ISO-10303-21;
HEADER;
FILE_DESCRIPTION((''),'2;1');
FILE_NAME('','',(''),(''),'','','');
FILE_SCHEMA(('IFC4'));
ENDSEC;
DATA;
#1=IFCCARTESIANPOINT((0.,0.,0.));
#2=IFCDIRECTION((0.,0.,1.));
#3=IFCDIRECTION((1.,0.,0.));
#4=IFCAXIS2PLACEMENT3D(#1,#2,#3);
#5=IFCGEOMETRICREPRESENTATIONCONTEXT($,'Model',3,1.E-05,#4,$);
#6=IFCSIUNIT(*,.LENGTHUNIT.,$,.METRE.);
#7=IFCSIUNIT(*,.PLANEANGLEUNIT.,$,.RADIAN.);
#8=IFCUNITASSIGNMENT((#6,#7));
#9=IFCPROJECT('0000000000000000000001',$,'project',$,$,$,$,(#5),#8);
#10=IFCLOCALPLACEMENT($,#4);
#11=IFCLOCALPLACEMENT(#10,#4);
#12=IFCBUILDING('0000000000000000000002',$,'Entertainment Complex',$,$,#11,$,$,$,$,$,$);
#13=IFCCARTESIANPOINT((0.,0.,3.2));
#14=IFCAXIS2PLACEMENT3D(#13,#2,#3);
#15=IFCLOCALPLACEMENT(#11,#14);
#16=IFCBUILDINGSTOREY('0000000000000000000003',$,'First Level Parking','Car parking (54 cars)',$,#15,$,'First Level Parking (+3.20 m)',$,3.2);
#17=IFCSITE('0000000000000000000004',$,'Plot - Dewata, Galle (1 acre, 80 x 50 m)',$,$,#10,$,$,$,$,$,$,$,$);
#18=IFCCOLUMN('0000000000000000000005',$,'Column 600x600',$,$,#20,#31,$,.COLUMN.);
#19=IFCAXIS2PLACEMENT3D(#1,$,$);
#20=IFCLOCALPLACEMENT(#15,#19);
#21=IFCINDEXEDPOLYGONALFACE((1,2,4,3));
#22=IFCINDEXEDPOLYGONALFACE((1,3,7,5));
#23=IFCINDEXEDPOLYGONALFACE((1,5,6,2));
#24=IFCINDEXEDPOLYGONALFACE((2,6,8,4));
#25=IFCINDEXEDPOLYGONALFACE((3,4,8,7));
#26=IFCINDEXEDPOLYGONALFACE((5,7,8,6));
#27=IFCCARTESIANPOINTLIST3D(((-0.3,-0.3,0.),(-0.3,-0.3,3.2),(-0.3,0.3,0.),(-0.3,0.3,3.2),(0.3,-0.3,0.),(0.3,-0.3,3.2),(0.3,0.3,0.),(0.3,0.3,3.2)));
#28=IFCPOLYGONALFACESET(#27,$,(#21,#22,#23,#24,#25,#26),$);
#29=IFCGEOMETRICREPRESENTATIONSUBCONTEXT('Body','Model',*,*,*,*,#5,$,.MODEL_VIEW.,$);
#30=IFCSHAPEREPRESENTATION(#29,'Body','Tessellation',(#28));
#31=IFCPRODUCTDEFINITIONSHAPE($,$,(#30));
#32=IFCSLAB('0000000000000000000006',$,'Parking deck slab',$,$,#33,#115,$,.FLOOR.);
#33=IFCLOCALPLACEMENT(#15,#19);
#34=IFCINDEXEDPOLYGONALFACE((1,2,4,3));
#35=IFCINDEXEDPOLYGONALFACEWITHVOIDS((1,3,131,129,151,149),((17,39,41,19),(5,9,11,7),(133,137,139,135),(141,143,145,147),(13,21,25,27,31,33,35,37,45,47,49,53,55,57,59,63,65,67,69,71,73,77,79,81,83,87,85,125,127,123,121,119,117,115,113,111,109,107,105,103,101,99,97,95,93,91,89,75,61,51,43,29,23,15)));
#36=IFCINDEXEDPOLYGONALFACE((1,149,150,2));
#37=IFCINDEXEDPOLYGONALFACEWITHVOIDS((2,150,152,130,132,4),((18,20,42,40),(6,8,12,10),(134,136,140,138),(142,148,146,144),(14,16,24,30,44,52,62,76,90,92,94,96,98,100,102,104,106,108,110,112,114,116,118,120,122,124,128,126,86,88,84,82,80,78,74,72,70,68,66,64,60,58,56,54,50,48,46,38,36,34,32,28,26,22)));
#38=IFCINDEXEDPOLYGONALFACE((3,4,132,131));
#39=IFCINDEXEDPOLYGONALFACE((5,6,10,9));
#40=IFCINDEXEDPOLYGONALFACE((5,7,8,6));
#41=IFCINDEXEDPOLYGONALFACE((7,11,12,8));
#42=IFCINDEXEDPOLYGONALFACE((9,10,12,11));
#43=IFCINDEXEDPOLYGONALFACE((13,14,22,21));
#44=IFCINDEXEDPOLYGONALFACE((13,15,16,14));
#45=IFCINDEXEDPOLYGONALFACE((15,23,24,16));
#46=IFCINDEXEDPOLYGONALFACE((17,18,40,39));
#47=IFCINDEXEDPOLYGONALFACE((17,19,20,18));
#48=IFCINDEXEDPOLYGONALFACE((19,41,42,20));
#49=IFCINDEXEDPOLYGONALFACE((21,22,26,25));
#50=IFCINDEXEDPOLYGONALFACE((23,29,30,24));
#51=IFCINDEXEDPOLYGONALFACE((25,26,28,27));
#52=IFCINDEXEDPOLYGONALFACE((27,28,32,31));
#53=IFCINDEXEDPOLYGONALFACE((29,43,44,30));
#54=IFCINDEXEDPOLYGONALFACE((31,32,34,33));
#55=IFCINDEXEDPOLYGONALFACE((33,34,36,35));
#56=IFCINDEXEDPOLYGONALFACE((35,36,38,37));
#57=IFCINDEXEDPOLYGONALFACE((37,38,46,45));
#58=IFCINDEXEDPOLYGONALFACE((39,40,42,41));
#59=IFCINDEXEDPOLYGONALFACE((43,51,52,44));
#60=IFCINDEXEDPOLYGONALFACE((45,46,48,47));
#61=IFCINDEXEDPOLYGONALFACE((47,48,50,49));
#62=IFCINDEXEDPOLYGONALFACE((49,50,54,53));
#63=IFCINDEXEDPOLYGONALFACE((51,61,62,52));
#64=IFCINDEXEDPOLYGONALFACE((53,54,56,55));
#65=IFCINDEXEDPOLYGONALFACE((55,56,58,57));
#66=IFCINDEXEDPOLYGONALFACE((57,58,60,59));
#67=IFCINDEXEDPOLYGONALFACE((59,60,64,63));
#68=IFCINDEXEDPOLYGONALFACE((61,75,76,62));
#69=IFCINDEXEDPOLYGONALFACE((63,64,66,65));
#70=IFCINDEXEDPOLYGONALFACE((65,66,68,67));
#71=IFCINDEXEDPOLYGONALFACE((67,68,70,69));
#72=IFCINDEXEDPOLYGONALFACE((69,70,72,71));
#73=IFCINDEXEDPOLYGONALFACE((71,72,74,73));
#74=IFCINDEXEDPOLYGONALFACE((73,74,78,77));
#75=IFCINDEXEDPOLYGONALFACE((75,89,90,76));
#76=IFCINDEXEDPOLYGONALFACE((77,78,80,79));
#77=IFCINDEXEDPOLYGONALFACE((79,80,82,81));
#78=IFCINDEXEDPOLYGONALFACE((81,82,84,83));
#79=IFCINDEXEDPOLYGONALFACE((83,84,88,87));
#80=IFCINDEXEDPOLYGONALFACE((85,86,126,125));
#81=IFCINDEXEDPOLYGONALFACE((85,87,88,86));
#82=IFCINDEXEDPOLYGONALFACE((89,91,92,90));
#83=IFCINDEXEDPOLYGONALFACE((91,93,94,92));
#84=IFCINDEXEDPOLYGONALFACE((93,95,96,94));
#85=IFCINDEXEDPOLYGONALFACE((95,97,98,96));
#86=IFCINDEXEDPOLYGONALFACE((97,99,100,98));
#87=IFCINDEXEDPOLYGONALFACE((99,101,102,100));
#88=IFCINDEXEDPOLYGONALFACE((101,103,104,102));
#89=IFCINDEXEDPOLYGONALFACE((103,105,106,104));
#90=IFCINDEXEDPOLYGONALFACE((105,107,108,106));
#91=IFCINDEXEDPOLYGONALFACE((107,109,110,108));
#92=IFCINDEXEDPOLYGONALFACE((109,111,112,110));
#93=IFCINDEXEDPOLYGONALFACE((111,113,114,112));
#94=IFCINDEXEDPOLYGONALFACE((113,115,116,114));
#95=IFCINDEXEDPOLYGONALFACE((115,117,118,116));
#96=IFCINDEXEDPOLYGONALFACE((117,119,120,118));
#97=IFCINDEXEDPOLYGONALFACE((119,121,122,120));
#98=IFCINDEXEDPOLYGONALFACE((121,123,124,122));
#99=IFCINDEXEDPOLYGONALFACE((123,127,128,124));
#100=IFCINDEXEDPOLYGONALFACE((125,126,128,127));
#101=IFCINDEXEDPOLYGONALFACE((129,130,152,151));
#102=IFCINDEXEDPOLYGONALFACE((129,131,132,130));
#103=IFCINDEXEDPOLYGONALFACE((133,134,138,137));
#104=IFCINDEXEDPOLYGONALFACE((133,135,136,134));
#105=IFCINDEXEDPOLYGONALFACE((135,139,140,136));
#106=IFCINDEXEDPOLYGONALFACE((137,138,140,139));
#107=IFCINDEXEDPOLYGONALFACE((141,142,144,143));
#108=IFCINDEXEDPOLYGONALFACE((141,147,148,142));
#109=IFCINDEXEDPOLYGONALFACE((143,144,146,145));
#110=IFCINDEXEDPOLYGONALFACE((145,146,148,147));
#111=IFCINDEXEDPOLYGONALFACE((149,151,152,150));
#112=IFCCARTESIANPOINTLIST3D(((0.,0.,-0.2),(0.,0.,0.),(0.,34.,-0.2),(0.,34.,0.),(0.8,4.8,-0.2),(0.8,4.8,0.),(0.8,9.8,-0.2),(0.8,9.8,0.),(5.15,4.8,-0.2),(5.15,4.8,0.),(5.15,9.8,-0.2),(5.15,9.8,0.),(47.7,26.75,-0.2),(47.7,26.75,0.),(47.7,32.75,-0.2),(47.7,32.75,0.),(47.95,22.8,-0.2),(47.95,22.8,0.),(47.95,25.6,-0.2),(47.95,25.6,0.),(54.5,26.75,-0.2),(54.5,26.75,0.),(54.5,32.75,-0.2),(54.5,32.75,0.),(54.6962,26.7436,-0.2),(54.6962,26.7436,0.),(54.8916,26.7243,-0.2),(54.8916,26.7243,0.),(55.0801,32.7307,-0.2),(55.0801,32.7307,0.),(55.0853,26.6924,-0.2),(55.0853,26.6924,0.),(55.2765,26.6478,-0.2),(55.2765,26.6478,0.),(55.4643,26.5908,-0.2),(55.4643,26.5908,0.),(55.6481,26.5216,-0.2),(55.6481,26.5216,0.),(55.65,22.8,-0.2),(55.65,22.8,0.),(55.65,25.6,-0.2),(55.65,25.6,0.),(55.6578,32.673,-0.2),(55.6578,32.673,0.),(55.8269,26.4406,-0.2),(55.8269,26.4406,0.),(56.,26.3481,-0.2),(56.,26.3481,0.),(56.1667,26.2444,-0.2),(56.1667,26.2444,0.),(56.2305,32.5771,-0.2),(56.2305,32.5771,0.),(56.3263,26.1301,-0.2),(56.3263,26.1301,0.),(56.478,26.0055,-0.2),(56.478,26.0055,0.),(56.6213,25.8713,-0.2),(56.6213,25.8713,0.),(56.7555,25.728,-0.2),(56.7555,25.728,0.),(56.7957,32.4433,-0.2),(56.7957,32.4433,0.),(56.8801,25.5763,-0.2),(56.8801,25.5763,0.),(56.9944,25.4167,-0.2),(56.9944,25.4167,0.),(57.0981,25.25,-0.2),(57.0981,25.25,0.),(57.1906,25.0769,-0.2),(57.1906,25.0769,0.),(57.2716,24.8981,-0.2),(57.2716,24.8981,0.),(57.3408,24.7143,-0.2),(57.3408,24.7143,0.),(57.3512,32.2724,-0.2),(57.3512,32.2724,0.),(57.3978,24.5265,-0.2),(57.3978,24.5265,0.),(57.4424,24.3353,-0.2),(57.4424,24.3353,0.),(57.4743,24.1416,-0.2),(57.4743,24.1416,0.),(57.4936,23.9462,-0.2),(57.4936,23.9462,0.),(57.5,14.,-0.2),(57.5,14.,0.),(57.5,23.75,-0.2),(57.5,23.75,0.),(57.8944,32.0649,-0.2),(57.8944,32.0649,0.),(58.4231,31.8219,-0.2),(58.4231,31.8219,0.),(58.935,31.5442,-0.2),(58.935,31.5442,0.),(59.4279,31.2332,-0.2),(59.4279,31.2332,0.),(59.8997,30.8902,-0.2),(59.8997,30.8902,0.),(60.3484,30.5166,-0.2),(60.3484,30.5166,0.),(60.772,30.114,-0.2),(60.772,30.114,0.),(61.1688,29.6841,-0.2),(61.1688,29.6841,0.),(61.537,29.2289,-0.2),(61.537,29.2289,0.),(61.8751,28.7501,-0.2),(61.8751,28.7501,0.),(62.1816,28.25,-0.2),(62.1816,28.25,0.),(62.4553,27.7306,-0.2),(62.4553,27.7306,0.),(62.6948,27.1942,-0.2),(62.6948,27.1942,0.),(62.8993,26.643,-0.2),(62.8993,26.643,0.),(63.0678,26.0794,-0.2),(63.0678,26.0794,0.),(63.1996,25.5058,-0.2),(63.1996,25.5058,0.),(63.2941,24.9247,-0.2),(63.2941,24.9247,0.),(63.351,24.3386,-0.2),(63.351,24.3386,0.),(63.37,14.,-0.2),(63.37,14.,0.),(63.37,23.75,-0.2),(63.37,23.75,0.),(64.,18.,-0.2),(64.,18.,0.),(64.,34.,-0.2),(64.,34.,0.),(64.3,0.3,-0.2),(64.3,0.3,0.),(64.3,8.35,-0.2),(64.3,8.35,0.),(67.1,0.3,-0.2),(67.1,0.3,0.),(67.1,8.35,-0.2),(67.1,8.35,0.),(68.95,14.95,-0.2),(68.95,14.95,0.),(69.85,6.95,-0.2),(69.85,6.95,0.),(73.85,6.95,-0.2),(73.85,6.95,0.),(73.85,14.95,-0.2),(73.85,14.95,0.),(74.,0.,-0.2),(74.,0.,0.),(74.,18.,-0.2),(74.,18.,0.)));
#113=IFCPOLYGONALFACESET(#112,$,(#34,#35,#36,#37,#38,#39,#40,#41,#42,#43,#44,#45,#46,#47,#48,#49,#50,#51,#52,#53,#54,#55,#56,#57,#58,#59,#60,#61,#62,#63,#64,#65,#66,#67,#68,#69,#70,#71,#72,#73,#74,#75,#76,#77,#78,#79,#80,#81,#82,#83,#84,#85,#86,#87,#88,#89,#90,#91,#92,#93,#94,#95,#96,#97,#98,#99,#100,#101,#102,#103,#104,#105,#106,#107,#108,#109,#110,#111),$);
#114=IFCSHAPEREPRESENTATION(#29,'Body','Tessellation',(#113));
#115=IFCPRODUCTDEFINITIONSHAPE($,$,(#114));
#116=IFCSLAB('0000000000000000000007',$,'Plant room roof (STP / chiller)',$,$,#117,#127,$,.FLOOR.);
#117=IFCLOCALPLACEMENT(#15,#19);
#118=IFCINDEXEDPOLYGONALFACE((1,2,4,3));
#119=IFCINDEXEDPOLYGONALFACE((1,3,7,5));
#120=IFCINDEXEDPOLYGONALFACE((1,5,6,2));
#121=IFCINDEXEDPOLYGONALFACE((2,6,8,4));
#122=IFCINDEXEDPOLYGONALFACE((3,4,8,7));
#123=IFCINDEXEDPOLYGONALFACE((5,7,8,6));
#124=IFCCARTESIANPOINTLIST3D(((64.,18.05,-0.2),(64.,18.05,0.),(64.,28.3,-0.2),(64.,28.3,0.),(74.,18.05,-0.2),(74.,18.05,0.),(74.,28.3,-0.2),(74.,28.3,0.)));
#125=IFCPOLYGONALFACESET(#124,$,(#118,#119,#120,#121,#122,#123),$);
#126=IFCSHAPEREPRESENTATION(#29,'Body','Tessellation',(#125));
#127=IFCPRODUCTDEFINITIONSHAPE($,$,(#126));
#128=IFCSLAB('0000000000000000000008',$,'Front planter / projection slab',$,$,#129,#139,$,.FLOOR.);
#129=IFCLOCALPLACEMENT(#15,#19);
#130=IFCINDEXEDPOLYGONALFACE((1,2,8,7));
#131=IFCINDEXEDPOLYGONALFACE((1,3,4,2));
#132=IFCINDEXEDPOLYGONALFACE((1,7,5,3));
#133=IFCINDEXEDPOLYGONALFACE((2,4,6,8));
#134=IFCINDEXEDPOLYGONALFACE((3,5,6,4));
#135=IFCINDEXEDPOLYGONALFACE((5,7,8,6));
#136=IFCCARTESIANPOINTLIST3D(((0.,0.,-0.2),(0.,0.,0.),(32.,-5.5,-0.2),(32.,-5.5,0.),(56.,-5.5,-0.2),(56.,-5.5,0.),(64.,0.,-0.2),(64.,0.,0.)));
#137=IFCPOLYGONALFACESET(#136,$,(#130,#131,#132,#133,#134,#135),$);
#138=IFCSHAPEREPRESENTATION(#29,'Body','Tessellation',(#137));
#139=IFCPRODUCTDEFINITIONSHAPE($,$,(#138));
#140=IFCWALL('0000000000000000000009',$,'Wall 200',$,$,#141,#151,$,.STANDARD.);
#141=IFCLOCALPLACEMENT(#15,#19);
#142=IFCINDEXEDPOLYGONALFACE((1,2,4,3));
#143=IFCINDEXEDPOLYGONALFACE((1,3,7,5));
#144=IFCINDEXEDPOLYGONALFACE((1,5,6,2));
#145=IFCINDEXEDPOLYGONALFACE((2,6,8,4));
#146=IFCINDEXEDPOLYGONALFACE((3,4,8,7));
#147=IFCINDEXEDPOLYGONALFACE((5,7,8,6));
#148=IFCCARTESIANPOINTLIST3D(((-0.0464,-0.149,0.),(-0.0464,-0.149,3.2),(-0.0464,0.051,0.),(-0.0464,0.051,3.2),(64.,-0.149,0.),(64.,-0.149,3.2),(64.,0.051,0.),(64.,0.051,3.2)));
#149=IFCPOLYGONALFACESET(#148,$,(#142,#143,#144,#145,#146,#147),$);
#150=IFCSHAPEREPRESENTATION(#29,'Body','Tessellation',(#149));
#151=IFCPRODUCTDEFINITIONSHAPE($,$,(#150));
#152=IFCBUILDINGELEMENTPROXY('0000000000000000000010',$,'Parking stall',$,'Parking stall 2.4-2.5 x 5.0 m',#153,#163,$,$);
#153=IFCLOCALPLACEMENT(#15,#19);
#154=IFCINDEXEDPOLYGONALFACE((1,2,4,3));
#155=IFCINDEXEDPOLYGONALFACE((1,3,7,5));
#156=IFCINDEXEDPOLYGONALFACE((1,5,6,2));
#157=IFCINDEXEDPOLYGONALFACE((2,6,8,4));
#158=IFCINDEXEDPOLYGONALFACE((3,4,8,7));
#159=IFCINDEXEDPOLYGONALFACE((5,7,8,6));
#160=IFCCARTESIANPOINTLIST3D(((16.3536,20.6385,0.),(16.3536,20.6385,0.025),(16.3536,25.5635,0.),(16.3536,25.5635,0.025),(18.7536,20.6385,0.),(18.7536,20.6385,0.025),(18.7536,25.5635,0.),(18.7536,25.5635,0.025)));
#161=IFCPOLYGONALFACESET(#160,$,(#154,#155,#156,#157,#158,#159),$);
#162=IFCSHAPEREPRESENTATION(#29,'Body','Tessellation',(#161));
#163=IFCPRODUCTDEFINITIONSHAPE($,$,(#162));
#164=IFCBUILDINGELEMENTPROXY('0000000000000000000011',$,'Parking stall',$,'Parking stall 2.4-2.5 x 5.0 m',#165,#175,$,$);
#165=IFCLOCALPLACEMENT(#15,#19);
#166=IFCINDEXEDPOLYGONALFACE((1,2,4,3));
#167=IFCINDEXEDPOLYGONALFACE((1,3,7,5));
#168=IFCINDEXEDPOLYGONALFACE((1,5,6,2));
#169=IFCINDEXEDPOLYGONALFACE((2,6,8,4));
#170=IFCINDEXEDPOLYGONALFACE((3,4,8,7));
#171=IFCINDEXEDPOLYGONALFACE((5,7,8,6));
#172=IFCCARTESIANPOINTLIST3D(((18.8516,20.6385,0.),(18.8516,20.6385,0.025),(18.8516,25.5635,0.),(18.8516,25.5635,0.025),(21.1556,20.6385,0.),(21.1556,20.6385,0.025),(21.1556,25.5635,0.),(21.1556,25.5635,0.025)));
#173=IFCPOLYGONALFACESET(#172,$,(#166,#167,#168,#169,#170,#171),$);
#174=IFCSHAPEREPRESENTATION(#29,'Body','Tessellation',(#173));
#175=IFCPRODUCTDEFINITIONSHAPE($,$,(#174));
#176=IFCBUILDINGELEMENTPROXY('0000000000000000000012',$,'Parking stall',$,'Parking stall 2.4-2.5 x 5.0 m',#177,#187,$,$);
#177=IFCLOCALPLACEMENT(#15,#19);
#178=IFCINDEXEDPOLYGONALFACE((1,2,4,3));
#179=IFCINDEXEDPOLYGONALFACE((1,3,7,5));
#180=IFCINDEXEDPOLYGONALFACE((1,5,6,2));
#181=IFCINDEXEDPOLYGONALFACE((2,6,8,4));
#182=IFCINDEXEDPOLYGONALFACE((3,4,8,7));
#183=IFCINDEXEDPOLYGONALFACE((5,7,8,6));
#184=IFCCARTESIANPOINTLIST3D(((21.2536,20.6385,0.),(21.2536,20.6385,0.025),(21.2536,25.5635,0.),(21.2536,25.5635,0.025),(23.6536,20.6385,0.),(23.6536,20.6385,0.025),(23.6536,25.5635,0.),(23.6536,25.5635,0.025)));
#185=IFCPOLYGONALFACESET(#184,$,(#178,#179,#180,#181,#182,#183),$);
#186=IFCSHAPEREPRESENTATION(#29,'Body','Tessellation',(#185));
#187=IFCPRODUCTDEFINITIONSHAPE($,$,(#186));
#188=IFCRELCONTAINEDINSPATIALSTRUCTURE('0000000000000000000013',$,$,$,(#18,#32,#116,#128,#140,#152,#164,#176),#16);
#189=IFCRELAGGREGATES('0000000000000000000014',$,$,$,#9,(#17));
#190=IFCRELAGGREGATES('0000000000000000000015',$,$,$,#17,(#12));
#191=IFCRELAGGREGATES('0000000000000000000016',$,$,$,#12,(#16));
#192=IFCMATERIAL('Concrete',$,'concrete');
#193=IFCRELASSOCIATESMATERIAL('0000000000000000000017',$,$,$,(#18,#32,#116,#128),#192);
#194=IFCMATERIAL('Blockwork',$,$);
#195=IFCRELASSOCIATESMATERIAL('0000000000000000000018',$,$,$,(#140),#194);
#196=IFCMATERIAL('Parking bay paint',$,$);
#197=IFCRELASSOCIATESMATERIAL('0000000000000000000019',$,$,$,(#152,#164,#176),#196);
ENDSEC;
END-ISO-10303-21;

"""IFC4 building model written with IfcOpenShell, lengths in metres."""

from ifc_helpers import new_model, si_unit, frame, origin_with_axes, place, context, subcontext, project, spatial, polyline, outline, extrude, material, element, save


model = new_model("IFC4")

# Units and contexts
model_context = context("Model", 3, precision=1e-05, world=origin_with_axes())
body_context = subcontext(model_context, "Body", "Model", "MODEL_VIEW")
ifc_project = project(units=[si_unit("LENGTHUNIT", "METRE"), si_unit("PLANEANGLEUNIT", "RADIAN")], contexts=[model_context])

# Site, building, storey
site_placement = place(None, origin_with_axes())
site = spatial("IfcSite", under=ifc_project, at=site_placement, Name="Plot - Dewata, Galle (1 acre, 80 x 50 m)")
building_placement = place(site_placement, origin_with_axes())
building = spatial("IfcBuilding", under=site, at=building_placement, Name="Entertainment Complex")
storey_placement = place(building_placement, frame((0.0, 0.0, 3.2), z_axis=(0.0, 0.0, 1.0), x_axis=(1.0, 0.0, 0.0)))
storey = spatial("IfcBuildingStorey", under=building, at=storey_placement, Name="First Level Parking", Description="Car parking (54 cars)", LongName="First Level Parking (+3.20 m)", Elevation=3.2)

# Column
ifc_material_1 = material(Name="Concrete", Category="concrete")
column_placement = place(storey_placement, origin_with_axes())
element("IfcColumn", 1, at=column_placement, inside=storey, material=ifc_material_1, Name="Column 600x600", PredefinedType="COLUMN", context=body_context, shape_type="SweptSolid", body=[
    extrude(outline(polyline([(-0.3, -0.3), (0.3, -0.3), (0.3, 0.3), (-0.3, 0.3), (-0.3, -0.3)])), origin_with_axes(), (0.0, 0.0, 1.0), 3.2),
])

# Slabs
slab_1_placement = place(storey_placement, origin_with_axes())
element("IfcSlab", 2, at=slab_1_placement, inside=storey, material=ifc_material_1, Name="Parking deck slab", PredefinedType="FLOOR", context=body_context, shape_type="SweptSolid", body=[
    extrude(outline(polyline([(74.0, 18.0), (64.0, 18.0), (64.0, 34.0), (0.0, 34.0), (0.0, 0.0), (74.0, 0.0), (74.0, 18.0)]), holes=[polyline([(63.2941, 24.9247), (63.351, 24.3386), (63.37, 23.75), (63.37, 14.0), (57.5, 14.0), (57.5, 23.75), (57.4936, 23.9462), (57.4743, 24.1416), (57.4424, 24.3353), (57.3978, 24.5265), (57.3408, 24.7143), (57.2716, 24.8981), (57.1906, 25.0769), (57.0981, 25.25), (56.9944, 25.4167), (56.8801, 25.5763), (56.7555, 25.728), (56.6213, 25.8713), (56.478, 26.0055), (56.3263, 26.1301), (56.1667, 26.2444), (56.0, 26.3481), (55.8269, 26.4406), (55.6481, 26.5216), (55.4643, 26.5908), (55.2765, 26.6478), (55.0853, 26.6924), (54.8916, 26.7243), (54.6962, 26.7436), (54.5, 26.75), (47.7, 26.75), (47.7, 32.75), (54.5, 32.75), (55.0801, 32.7307), (55.6578, 32.673), (56.2305, 32.5771), (56.7957, 32.4433), (57.3512, 32.2724), (57.8944, 32.0649), (58.4231, 31.8219), (58.935, 31.5442), (59.4279, 31.2332), (59.8997, 30.8902), (60.3484, 30.5166), (60.772, 30.114), (61.1688, 29.6841), (61.537, 29.2289), (61.8751, 28.7501), (62.1816, 28.25), (62.4553, 27.7306), (62.6948, 27.1942), (62.8993, 26.643), (63.0678, 26.0794), (63.1996, 25.5058), (63.2941, 24.9247)]), polyline([(0.8, 9.8), (5.15, 9.8), (5.15, 4.8), (0.8, 4.8), (0.8, 9.8)]), polyline([(73.85, 6.95), (69.85, 6.95), (68.95, 14.95), (73.85, 14.95), (73.85, 6.95)]), polyline([(55.65, 22.8), (47.95, 22.8), (47.95, 25.6), (55.65, 25.6), (55.65, 22.8)]), polyline([(64.3, 0.3), (64.3, 8.35), (67.1, 8.35), (67.1, 0.3), (64.3, 0.3)])]), frame((0.0, 0.0, -0.2), z_axis=(0.0, 0.0, 1.0), x_axis=(1.0, 0.0, 0.0)), (0.0, 0.0, 1.0), 0.2),
])
slab_2_placement = place(storey_placement, origin_with_axes())
element("IfcSlab", 3, at=slab_2_placement, inside=storey, material=ifc_material_1, Name="Plant room roof (STP / chiller)", PredefinedType="FLOOR", context=body_context, shape_type="SweptSolid", body=[
    extrude(outline(polyline([(74.0, 18.05), (74.0, 28.3), (64.0, 28.3), (64.0, 18.05), (74.0, 18.05)])), frame((0.0, 0.0, -0.2), z_axis=(0.0, 0.0, 1.0), x_axis=(1.0, 0.0, 0.0)), (0.0, 0.0, 1.0), 0.2),
])
slab_3_placement = place(storey_placement, origin_with_axes())
element("IfcSlab", 4, at=slab_3_placement, inside=storey, material=ifc_material_1, Name="Front planter / projection slab", PredefinedType="FLOOR", context=body_context, shape_type="SweptSolid", body=[
    extrude(outline(polyline([(0.0, 0.0), (32.0, -5.5), (56.0, -5.5), (64.0, 0.0), (0.0, 0.0)])), frame((0.0, 0.0, -0.2), z_axis=(0.0, 0.0, 1.0), x_axis=(1.0, 0.0, 0.0)), (0.0, 0.0, 1.0), 0.2),
])

# Wall
ifc_material_2 = material(Name="Blockwork")
wall_placement = place(storey_placement, frame((-0.0464, -0.049, 0.0), z_axis=(0.0, 0.0, 1.0), x_axis=(1.0, 0.0, 0.0)))
element("IfcWall", 5, at=wall_placement, inside=storey, material=ifc_material_2, Name="Wall 200", PredefinedType="STANDARD", context=body_context, shape_type="SweptSolid", body=[
    extrude(outline(polyline([(0.0, -0.1), (64.0464, -0.1), (64.0464, 0.1), (0.0, 0.1), (0.0, -0.1)])), origin_with_axes(), (0.0, 0.0, 1.0), 3.2),
])

# Building element proxies
ifc_material_3 = material(Name="Parking bay paint")
proxy_1_placement = place(storey_placement, origin_with_axes())
element("IfcBuildingElementProxy", 6, at=proxy_1_placement, inside=storey, material=ifc_material_3, Name="Parking stall", ObjectType="Parking stall 2.4-2.5 x 5.0 m", context=body_context, shape_type="SweptSolid", body=[
    extrude(outline(polyline([(16.3536, 20.6385), (18.7536, 20.6385), (18.7536, 25.5635), (16.3536, 25.5635), (16.3536, 20.6385)])), origin_with_axes(), (0.0, 0.0, 1.0), 0.025),
])
proxy_2_placement = place(storey_placement, origin_with_axes())
element("IfcBuildingElementProxy", 7, at=proxy_2_placement, inside=storey, material=ifc_material_3, Name="Parking stall", ObjectType="Parking stall 2.4-2.5 x 5.0 m", context=body_context, shape_type="SweptSolid", body=[
    extrude(outline(polyline([(18.8516, 20.6385), (21.1556, 20.6385), (21.1556, 25.5635), (18.8516, 25.5635), (18.8516, 20.6385)])), origin_with_axes(), (0.0, 0.0, 1.0), 0.025),
])
proxy_3_placement = place(storey_placement, origin_with_axes())
element("IfcBuildingElementProxy", 8, at=proxy_3_placement, inside=storey, material=ifc_material_3, Name="Parking stall", ObjectType="Parking stall 2.4-2.5 x 5.0 m", context=body_context, shape_type="SweptSolid", body=[
    extrude(outline(polyline([(21.2536, 20.6385), (23.6536, 20.6385), (23.6536, 25.5635), (21.2536, 25.5635), (21.2536, 20.6385)])), origin_with_axes(), (0.0, 0.0, 1.0), 0.025),
])

save(model, "model.ifc")
